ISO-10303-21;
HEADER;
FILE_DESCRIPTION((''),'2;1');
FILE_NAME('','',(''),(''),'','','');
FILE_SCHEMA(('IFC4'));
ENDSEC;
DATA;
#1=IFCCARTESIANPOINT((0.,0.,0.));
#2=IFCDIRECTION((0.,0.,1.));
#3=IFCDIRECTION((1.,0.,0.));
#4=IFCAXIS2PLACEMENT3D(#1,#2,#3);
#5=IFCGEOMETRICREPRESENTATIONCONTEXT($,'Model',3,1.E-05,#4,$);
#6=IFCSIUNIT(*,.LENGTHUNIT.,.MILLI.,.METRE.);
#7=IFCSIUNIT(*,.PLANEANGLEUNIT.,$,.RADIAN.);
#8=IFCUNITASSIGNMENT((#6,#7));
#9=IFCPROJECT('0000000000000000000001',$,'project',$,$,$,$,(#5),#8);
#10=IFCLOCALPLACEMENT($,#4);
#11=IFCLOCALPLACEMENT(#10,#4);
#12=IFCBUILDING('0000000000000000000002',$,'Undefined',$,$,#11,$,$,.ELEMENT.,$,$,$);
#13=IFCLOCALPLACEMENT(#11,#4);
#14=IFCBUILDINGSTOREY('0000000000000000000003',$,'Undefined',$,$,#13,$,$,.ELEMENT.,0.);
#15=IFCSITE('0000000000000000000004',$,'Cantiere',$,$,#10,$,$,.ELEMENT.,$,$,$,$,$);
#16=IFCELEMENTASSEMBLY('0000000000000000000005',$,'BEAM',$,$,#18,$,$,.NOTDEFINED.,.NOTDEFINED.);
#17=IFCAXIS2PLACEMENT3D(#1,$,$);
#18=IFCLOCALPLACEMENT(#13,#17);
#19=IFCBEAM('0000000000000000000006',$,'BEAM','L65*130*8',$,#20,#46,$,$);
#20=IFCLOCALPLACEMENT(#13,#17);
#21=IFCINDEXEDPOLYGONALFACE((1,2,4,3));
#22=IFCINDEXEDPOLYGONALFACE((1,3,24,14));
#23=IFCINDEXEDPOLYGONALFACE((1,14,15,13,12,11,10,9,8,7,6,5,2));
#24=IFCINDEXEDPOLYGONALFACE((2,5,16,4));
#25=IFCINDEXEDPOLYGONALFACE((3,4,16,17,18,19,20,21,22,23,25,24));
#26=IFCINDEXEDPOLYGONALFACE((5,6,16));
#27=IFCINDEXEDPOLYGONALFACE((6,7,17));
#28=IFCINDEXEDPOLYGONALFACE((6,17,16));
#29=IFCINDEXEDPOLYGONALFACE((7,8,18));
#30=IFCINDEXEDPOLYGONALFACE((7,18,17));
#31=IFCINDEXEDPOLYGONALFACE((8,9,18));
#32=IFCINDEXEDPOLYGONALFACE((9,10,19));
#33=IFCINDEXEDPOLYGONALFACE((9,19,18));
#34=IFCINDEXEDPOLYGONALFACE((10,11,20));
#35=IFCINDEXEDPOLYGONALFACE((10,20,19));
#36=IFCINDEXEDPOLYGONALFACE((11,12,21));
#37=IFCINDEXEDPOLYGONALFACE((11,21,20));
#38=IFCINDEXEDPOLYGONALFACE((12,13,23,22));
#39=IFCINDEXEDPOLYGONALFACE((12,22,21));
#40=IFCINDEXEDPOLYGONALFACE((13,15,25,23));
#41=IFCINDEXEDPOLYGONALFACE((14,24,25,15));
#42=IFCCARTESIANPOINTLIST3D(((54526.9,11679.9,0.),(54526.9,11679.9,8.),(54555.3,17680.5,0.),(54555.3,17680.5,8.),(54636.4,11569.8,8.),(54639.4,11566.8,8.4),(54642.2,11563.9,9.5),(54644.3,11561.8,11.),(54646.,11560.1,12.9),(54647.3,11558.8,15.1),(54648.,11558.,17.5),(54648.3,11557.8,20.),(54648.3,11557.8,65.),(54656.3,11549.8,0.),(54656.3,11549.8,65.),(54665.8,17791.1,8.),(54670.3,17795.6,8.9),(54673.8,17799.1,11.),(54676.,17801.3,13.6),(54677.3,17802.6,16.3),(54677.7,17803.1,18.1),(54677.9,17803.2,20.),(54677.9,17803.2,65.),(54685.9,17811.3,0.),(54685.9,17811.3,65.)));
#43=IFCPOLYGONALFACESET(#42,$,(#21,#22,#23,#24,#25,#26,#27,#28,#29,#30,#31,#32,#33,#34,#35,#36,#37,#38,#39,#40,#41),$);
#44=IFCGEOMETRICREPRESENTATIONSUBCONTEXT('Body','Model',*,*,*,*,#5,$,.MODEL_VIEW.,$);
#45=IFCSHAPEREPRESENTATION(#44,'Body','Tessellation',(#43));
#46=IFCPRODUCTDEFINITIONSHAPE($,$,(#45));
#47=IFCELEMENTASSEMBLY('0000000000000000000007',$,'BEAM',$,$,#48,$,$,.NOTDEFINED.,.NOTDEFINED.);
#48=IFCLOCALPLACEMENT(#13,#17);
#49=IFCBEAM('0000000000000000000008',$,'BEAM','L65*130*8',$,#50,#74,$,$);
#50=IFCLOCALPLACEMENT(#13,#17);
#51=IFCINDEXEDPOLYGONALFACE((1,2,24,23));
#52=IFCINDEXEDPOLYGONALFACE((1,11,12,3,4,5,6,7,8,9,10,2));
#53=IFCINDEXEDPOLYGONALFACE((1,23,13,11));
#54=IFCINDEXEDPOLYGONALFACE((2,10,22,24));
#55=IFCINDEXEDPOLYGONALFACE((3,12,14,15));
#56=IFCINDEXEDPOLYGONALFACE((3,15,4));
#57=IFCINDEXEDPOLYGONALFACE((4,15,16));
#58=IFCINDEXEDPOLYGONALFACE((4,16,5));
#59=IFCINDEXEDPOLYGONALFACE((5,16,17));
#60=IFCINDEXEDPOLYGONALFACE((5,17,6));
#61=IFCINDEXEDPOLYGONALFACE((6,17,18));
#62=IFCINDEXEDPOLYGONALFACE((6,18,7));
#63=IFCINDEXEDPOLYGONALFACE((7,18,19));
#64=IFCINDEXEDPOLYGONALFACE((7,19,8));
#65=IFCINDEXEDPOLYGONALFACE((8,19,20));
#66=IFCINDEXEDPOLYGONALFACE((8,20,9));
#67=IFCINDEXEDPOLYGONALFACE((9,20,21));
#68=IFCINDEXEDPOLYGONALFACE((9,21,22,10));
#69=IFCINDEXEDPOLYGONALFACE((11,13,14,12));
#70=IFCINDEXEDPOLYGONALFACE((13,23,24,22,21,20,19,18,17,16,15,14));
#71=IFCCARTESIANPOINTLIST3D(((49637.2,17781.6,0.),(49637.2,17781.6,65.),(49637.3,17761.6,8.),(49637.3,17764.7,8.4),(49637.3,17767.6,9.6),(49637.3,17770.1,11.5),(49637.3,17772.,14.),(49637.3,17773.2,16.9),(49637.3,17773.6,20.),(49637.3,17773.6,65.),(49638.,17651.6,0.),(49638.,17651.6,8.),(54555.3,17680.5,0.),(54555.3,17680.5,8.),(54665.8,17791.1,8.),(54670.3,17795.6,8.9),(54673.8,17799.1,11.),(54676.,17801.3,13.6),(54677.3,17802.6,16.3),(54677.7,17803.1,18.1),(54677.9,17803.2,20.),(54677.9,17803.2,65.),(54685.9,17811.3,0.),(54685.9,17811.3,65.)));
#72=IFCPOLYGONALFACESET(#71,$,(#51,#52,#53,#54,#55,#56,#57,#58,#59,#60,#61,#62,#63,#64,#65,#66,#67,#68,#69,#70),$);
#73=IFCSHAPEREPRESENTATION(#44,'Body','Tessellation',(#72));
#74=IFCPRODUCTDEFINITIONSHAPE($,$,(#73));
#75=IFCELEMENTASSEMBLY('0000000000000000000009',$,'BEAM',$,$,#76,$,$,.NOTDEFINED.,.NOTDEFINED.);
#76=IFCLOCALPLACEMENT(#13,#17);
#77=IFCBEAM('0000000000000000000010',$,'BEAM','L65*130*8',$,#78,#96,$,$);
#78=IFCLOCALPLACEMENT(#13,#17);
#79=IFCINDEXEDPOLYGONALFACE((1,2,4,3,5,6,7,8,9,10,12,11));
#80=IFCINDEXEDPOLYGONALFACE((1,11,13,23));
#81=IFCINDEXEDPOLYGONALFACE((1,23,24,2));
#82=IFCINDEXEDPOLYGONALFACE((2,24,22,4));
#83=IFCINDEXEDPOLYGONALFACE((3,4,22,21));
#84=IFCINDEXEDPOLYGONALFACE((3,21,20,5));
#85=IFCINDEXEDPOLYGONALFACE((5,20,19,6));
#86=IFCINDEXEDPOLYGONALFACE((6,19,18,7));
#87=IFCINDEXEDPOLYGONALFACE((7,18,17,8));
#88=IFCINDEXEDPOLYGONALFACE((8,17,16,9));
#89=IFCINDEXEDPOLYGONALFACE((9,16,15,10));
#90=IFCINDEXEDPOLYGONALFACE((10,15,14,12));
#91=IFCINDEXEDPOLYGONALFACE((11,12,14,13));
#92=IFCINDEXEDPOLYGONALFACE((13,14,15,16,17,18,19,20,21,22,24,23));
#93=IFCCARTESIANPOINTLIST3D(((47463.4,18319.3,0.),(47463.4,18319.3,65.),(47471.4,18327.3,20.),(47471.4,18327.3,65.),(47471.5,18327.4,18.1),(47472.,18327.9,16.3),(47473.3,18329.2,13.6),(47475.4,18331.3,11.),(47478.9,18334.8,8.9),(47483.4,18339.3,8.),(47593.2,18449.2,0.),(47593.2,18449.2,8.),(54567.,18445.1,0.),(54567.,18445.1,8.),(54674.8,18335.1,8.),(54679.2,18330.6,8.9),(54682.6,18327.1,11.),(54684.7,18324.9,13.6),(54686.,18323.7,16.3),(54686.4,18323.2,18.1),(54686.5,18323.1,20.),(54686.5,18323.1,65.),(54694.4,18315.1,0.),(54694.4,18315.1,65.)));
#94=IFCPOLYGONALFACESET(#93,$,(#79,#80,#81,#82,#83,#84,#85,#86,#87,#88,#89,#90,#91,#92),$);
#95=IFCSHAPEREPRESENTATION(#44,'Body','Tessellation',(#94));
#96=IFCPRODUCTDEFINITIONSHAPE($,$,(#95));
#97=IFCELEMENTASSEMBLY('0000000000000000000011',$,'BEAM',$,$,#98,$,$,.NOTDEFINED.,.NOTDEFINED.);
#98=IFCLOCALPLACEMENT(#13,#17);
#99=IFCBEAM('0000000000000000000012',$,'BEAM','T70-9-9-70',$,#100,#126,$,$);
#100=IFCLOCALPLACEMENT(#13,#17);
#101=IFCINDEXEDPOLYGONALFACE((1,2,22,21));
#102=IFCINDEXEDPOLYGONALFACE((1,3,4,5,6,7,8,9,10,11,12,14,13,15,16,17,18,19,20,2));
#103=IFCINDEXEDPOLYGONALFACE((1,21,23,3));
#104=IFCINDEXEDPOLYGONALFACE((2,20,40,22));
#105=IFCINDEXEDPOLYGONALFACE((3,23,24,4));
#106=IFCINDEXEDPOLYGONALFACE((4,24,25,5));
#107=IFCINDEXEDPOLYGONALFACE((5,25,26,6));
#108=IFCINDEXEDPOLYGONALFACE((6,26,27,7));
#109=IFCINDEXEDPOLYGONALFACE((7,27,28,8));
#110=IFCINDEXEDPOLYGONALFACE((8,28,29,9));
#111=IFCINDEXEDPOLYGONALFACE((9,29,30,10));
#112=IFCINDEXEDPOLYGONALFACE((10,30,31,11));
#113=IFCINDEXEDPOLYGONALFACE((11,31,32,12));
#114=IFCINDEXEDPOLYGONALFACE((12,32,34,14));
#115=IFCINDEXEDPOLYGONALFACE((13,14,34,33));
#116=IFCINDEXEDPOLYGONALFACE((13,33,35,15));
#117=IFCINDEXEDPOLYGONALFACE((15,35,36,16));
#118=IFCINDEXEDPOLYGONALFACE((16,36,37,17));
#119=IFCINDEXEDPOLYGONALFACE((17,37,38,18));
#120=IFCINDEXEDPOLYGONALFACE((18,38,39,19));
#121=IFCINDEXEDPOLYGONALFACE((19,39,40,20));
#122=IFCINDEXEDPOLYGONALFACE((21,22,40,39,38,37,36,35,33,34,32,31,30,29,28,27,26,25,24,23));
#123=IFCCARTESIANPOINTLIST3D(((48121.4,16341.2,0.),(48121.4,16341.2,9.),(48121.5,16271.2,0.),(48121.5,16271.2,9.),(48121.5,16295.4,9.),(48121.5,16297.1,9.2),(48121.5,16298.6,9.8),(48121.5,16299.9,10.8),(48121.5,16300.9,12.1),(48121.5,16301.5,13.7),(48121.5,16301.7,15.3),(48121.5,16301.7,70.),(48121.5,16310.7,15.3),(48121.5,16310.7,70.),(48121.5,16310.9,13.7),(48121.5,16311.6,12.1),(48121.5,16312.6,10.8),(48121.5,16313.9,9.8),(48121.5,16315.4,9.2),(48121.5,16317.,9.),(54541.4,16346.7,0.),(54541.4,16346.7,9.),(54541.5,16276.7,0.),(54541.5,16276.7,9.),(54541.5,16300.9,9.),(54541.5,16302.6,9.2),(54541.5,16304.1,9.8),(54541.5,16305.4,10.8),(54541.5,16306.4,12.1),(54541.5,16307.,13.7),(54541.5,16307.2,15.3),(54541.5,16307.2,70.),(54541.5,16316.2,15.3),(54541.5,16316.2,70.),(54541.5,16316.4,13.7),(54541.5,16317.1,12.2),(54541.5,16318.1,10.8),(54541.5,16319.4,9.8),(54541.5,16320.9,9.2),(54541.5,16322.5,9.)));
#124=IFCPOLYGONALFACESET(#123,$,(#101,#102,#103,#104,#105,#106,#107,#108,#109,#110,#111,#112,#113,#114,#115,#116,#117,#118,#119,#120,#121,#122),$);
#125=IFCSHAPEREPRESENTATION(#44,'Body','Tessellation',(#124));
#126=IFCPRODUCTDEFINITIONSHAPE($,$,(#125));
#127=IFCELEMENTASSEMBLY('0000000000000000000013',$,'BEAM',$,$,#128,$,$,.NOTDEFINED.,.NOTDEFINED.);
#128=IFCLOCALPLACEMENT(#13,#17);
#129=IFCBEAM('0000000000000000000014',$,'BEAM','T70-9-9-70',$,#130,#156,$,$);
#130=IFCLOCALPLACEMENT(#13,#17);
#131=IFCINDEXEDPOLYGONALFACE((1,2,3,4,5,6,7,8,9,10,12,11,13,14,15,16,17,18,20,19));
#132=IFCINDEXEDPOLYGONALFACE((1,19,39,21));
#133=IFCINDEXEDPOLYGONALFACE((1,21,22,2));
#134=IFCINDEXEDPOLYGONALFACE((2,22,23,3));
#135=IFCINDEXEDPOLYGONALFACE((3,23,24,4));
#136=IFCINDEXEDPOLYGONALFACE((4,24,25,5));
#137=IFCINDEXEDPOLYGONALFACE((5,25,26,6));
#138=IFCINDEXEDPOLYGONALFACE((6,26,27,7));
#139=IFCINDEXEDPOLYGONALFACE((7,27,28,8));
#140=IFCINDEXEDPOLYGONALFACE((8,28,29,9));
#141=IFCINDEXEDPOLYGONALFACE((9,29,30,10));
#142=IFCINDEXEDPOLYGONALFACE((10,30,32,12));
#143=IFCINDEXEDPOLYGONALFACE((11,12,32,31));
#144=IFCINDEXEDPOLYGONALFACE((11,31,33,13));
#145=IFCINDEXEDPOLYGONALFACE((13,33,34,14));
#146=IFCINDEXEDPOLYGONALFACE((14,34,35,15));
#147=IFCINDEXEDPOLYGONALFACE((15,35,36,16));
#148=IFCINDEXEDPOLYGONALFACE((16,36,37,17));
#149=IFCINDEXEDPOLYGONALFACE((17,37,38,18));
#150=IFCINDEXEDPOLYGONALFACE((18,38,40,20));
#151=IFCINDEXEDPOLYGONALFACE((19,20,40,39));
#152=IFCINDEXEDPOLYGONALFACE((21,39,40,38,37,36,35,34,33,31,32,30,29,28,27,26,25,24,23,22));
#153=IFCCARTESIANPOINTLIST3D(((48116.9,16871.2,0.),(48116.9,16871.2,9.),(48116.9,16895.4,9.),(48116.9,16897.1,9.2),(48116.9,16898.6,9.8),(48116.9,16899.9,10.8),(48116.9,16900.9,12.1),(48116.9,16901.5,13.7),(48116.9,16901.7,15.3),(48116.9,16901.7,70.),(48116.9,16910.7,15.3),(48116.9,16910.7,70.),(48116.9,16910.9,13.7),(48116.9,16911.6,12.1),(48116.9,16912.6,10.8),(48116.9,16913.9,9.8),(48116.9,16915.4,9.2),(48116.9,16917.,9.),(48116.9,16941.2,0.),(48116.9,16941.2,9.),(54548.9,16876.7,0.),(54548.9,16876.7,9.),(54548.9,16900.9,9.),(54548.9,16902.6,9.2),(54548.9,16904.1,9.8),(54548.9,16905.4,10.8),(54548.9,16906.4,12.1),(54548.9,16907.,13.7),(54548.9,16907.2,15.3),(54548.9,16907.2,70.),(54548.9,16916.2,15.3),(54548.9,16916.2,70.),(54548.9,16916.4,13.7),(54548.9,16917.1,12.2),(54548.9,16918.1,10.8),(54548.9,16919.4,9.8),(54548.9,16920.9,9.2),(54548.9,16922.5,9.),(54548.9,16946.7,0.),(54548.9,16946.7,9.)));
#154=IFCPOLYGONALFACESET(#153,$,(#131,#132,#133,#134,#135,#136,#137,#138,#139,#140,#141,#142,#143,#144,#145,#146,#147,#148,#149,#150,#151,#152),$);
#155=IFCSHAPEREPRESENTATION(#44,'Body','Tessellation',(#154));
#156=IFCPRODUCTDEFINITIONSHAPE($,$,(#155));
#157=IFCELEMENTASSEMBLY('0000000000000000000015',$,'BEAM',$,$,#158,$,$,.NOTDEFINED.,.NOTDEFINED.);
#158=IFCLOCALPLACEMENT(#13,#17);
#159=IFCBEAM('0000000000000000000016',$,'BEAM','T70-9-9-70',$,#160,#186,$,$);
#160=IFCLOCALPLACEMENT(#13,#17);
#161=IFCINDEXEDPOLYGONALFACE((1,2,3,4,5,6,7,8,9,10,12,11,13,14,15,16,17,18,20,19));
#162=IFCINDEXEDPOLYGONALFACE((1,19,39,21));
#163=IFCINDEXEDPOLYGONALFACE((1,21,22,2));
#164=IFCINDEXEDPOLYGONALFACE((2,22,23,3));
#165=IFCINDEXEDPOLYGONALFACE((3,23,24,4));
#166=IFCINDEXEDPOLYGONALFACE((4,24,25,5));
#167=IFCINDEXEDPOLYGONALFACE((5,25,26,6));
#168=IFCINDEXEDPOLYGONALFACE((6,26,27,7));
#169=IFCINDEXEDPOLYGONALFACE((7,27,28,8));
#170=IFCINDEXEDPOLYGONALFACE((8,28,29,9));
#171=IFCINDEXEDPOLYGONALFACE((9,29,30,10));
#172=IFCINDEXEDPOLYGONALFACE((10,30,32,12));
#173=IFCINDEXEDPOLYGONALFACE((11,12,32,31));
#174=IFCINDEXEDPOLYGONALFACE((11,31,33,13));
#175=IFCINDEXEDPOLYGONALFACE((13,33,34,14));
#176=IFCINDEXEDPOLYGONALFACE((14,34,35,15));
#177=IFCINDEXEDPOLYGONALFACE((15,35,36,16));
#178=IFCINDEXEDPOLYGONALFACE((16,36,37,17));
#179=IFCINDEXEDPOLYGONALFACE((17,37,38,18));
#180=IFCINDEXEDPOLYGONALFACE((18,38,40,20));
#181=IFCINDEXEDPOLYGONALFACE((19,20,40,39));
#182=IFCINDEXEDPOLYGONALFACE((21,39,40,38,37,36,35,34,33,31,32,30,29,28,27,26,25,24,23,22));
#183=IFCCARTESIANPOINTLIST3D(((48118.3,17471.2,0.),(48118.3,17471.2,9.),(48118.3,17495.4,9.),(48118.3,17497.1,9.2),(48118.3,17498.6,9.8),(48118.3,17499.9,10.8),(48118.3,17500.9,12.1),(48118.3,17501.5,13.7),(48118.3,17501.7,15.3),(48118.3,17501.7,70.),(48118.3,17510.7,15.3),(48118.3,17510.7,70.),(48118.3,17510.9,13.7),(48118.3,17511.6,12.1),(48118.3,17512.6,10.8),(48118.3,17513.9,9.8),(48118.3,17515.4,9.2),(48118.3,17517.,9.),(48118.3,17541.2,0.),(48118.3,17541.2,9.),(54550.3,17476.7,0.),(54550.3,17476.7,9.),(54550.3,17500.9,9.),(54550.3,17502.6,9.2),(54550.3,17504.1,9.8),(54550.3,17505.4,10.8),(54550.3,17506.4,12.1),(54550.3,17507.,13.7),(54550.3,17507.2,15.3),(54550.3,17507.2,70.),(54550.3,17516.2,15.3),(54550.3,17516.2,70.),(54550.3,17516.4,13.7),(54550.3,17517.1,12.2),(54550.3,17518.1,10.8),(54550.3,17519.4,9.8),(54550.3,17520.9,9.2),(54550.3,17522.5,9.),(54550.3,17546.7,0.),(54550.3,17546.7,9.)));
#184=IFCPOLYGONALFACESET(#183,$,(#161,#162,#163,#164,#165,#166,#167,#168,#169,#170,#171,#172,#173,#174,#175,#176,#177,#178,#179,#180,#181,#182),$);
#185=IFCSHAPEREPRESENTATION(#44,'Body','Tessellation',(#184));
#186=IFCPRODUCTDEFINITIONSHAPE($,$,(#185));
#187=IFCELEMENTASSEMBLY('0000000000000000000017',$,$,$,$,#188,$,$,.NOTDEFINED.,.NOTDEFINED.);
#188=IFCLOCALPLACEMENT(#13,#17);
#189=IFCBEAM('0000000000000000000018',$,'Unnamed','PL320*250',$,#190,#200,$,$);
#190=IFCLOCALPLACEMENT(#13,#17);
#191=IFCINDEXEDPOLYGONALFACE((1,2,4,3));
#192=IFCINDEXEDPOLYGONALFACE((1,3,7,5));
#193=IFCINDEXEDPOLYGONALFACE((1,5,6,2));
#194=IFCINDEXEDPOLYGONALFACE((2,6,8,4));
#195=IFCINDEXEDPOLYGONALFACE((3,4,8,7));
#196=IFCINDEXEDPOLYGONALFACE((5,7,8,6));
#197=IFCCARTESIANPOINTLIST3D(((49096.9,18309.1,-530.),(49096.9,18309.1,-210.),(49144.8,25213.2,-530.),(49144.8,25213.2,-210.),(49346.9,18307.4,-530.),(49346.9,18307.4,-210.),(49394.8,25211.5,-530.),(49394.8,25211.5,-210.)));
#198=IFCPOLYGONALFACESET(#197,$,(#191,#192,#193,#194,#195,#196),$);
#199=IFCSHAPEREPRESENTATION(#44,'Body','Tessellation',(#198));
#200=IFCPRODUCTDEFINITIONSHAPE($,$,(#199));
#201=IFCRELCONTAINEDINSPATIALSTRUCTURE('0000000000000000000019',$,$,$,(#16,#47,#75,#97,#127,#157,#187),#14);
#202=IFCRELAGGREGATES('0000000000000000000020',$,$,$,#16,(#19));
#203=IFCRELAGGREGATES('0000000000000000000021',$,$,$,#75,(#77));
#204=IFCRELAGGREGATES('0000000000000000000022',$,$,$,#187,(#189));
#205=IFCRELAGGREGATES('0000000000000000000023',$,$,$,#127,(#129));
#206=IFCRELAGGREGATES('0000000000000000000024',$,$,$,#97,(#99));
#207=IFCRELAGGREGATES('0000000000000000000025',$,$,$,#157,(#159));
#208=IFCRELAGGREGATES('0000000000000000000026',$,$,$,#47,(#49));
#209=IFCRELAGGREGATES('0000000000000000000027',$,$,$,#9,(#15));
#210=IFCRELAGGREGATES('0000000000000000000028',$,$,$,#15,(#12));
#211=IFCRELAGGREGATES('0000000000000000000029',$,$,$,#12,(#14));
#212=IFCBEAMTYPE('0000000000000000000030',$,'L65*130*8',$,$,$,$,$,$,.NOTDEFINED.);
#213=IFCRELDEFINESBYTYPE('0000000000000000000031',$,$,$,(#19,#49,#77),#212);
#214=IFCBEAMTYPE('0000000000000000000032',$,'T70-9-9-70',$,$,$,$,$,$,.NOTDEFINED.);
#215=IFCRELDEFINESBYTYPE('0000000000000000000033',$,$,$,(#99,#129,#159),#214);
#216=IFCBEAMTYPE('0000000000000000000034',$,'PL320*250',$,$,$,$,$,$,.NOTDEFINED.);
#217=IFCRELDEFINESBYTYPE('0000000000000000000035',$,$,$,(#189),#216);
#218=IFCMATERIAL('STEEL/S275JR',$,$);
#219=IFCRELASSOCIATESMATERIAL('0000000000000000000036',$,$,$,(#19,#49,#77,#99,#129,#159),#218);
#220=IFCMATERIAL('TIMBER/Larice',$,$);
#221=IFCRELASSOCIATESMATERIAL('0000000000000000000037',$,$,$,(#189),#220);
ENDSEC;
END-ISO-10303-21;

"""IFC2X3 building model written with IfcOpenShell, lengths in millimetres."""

from ifc_helpers import new_model, si_unit, frame, origin_with_axes, origin_2d_with_axis, place, context, subcontext, project, spatial, rectangle, l_section, t_section, extrude, clip, halfspace, material, type_object, element, aggregate, save


model = new_model("IFC2X3")

# Units and contexts
model_context = context("Model", 3, precision=1e-05, world=origin_with_axes())
body_context = subcontext(model_context, "Body", "Model", "MODEL_VIEW")
ifc_project = project(units=[si_unit("LENGTHUNIT", "METRE", prefix="MILLI"), si_unit("PLANEANGLEUNIT", "RADIAN")], contexts=[model_context])

# Site, building, storey
site_placement = place(None, origin_with_axes())
site = spatial("IfcSite", under=ifc_project, at=site_placement, Name="Cantiere", CompositionType="ELEMENT")
building_placement = place(site_placement, origin_with_axes())
building = spatial("IfcBuilding", under=site, at=building_placement, Name="Undefined", CompositionType="ELEMENT")
storey_placement = place(building_placement, origin_with_axes())
storey = spatial("IfcBuildingStorey", under=building, at=storey_placement, Name="Undefined", CompositionType="ELEMENT", Elevation=0.0)

# Element assemblies, beams
assembly_1_placement = place(storey_placement, origin_with_axes())
assembly_1 = element("IfcElementAssembly", 1, at=assembly_1_placement, inside=storey, Name="BEAM", AssemblyPlace="NOTDEFINED", PredefinedType="NOTDEFINED")
ifc_material_1 = material(Name="STEEL/S275JR")
beam_type_1 = type_object("IfcBeamType", Name="L65*130*8", PredefinedType="NOTDEFINED")
beam_1_placement = place(assembly_1_placement, frame((54620.9, 17809.6, 32.5), z_axis=(0.0, 0.0, 1.0), x_axis=(-0.004733, -0.999989, 0.0)))
beam_1 = element("IfcBeam", 2, at=beam_1_placement, type_object=beam_type_1, material=ifc_material_1, Name="BEAM", Description="L65*130*8", context=body_context, shape_type="Clipping", body=[
    clip(clip(extrude(l_section(Depth=65.0, Width=130.0, Thickness=8.0, FilletRadius=12.0, at=origin_2d_with_axis()), frame((6327.2, 0.0, 0.0), z_axis=(-1.0, 0.0, 0.0), x_axis=(0.0, -1.0, 0.0)), (0.0, 0.0, 1.0), 6395.9), halfspace(frame((6259.6, 65.0, -32.5), z_axis=(-0.708333, 0.705878, 0.0), x_axis=(0.0, 0.0, 1.0)), True)), halfspace(frame((129.4, -65.0, -32.5), z_axis=(0.703349, 0.710845, 0.0), x_axis=(0.0, 0.0, 1.0)), True)),
])
aggregate(assembly_1, [beam_1])
assembly_2_placement = place(storey_placement, origin_with_axes())
assembly_2 = element("IfcElementAssembly", 3, at=assembly_2_placement, inside=storey, Name="BEAM", AssemblyPlace="NOTDEFINED", PredefinedType="NOTDEFINED")
beam_2_placement = place(assembly_2_placement, frame((49637.6, 17716.6, 32.5), z_axis=(0.0, 0.0, 1.0), x_axis=(0.999983, 0.005867, 0.0)))
beam_2 = element("IfcBeam", 4, at=beam_2_placement, type_object=beam_type_1, material=ifc_material_1, Name="BEAM", Description="L65*130*8", context=body_context, shape_type="Clipping", body=[
    clip(extrude(l_section(Depth=65.0, Width=130.0, Thickness=8.0, FilletRadius=12.0, at=origin_2d_with_axis()), frame((5050.2, 0.0, 0.0), z_axis=(-1.0, 0.0, 0.0), x_axis=(0.0, -1.0, 0.0)), (0.0, 0.0, 1.0), 5050.2), halfspace(frame((4917.4, -65.0, -32.5), z_axis=(0.703349, -0.710845, 0.0), x_axis=(0.0, 0.0, 1.0)), False)),
])
assembly_3_placement = place(storey_placement, origin_with_axes())
assembly_3 = element("IfcElementAssembly", 5, at=assembly_3_placement, inside=storey, Name="BEAM", AssemblyPlace="NOTDEFINED", PredefinedType="NOTDEFINED")
beam_3_placement = place(assembly_3_placement, frame((54692.4, 18380.1, 32.5), z_axis=(0.0, 0.0, 1.0), x_axis=(-1.0, 0.000585, 0.0)))
beam_3 = element("IfcBeam", 6, at=beam_3_placement, type_object=beam_type_1, material=ifc_material_1, Name="BEAM", Description="L65*130*8", context=body_context, shape_type="Clipping", body=[
    clip(clip(extrude(l_section(Depth=65.0, Width=130.0, Thickness=8.0, FilletRadius=12.0, at=origin_2d_with_axis()), frame((7294.1, 0.0, 0.0), z_axis=(-1.0, 0.0, 0.0), x_axis=(0.0, -1.0, 0.0)), (0.0, 0.0, 1.0), 7362.3), halfspace(frame((7099.2, -65.0, -32.5), z_axis=(0.707749, -0.706464, 0.0), x_axis=(0.0, 0.0, 1.0)), False)), halfspace(frame((125.5, -65.0, -32.5), z_axis=(0.713962, 0.700184, 0.0), x_axis=(0.0, 0.0, 1.0)), True)),
])
aggregate(assembly_3, [beam_3])
assembly_4_placement = place(storey_placement, origin_with_axes())
assembly_4 = element("IfcElementAssembly", 7, at=assembly_4_placement, inside=storey, Name="BEAM", AssemblyPlace="NOTDEFINED", PredefinedType="NOTDEFINED")
beam_type_2 = type_object("IfcBeamType", Name="T70-9-9-70", PredefinedType="NOTDEFINED")
beam_4_placement = place(assembly_4_placement, frame((54541.5, 16311.7, 35.0), z_axis=(0.0, 0.000001, -1.0), x_axis=(-1.0, -0.000856, 0.0)))
beam_4 = element("IfcBeam", 8, at=beam_4_placement, type_object=beam_type_2, material=ifc_material_1, Name="BEAM", Description="T70-9-9-70", context=body_context, shape_type="SweptSolid", body=[
    extrude(t_section(Depth=70.0, FlangeWidth=70.0, WebThickness=9.0, FlangeThickness=9.0, FilletRadius=6.3, at=origin_2d_with_axis()), frame((6420.0, 0.0, 0.0), z_axis=(-1.0, 0.0, 0.0), x_axis=(0.0, -1.0, 0.0)), (0.0, 0.0, 1.0), 6420.0),
])
assembly_5_placement = place(storey_placement, origin_with_axes())
assembly_5 = element("IfcElementAssembly", 9, at=assembly_5_placement, inside=storey, Name="BEAM", AssemblyPlace="NOTDEFINED", PredefinedType="NOTDEFINED")
beam_5_placement = place(assembly_5_placement, frame((54548.9, 16911.7, 35.0), z_axis=(0.0, 0.000001, -1.0), x_axis=(-1.0, -0.000856, 0.0)))
beam_5 = element("IfcBeam", 10, at=beam_5_placement, type_object=beam_type_2, material=ifc_material_1, Name="BEAM", Description="T70-9-9-70", context=body_context, shape_type="SweptSolid", body=[
    extrude(t_section(Depth=70.0, FlangeWidth=70.0, WebThickness=9.0, FlangeThickness=9.0, FilletRadius=6.3, at=origin_2d_with_axis()), frame((6432.0, 0.0, 0.0), z_axis=(-1.0, 0.0, 0.0), x_axis=(0.0, -1.0, 0.0)), (0.0, 0.0, 1.0), 6432.0),
])
assembly_6_placement = place(storey_placement, origin_with_axes())
assembly_6 = element("IfcElementAssembly", 11, at=assembly_6_placement, inside=storey, Name="BEAM", AssemblyPlace="NOTDEFINED", PredefinedType="NOTDEFINED")
beam_6_placement = place(assembly_6_placement, frame((54550.3, 17511.7, 35.0), z_axis=(0.0, 0.000001, -1.0), x_axis=(-1.0, -0.000856, 0.0)))
beam_6 = element("IfcBeam", 12, at=beam_6_placement, type_object=beam_type_2, material=ifc_material_1, Name="BEAM", Description="T70-9-9-70", context=body_context, shape_type="SweptSolid", body=[
    extrude(t_section(Depth=70.0, FlangeWidth=70.0, WebThickness=9.0, FlangeThickness=9.0, FilletRadius=6.3, at=origin_2d_with_axis()), frame((6432.0, 0.0, 0.0), z_axis=(-1.0, 0.0, 0.0), x_axis=(0.0, -1.0, 0.0)), (0.0, 0.0, 1.0), 6432.0),
])
assembly_7_placement = place(storey_placement, origin_with_axes())
assembly_7 = element("IfcElementAssembly", 13, at=assembly_7_placement, inside=storey, AssemblyPlace="NOTDEFINED", PredefinedType="NOTDEFINED")
ifc_material_2 = material(Name="TIMBER/Larice")
beam_type_3 = type_object("IfcBeamType", Name="PL320*250", PredefinedType="NOTDEFINED")
beam_7_placement = place(assembly_7_placement, frame((49221.9, 18308.3, -370.0), z_axis=(0.0, 0.0, 1.0), x_axis=(0.00694, 0.999976, 0.0)))
beam_7 = element("IfcBeam", 14, at=beam_7_placement, type_object=beam_type_3, material=ifc_material_2, Name="Unnamed", Description="PL320*250", context=body_context, shape_type="SweptSolid", body=[
    extrude(rectangle(XDim=250.0, YDim=320.0, at=origin_2d_with_axis()), frame((6904.3, 0.0, 0.0), z_axis=(-1.0, 0.0, 0.0), x_axis=(0.0, -1.0, 0.0)), (0.0, 0.0, 1.0), 6904.3),
])
aggregate(assembly_7, [beam_7])

aggregate(assembly_5, [beam_5])
aggregate(assembly_4, [beam_4])
aggregate(assembly_6, [beam_6])

aggregate(assembly_2, [beam_2])

save(model, "model.ifc")
